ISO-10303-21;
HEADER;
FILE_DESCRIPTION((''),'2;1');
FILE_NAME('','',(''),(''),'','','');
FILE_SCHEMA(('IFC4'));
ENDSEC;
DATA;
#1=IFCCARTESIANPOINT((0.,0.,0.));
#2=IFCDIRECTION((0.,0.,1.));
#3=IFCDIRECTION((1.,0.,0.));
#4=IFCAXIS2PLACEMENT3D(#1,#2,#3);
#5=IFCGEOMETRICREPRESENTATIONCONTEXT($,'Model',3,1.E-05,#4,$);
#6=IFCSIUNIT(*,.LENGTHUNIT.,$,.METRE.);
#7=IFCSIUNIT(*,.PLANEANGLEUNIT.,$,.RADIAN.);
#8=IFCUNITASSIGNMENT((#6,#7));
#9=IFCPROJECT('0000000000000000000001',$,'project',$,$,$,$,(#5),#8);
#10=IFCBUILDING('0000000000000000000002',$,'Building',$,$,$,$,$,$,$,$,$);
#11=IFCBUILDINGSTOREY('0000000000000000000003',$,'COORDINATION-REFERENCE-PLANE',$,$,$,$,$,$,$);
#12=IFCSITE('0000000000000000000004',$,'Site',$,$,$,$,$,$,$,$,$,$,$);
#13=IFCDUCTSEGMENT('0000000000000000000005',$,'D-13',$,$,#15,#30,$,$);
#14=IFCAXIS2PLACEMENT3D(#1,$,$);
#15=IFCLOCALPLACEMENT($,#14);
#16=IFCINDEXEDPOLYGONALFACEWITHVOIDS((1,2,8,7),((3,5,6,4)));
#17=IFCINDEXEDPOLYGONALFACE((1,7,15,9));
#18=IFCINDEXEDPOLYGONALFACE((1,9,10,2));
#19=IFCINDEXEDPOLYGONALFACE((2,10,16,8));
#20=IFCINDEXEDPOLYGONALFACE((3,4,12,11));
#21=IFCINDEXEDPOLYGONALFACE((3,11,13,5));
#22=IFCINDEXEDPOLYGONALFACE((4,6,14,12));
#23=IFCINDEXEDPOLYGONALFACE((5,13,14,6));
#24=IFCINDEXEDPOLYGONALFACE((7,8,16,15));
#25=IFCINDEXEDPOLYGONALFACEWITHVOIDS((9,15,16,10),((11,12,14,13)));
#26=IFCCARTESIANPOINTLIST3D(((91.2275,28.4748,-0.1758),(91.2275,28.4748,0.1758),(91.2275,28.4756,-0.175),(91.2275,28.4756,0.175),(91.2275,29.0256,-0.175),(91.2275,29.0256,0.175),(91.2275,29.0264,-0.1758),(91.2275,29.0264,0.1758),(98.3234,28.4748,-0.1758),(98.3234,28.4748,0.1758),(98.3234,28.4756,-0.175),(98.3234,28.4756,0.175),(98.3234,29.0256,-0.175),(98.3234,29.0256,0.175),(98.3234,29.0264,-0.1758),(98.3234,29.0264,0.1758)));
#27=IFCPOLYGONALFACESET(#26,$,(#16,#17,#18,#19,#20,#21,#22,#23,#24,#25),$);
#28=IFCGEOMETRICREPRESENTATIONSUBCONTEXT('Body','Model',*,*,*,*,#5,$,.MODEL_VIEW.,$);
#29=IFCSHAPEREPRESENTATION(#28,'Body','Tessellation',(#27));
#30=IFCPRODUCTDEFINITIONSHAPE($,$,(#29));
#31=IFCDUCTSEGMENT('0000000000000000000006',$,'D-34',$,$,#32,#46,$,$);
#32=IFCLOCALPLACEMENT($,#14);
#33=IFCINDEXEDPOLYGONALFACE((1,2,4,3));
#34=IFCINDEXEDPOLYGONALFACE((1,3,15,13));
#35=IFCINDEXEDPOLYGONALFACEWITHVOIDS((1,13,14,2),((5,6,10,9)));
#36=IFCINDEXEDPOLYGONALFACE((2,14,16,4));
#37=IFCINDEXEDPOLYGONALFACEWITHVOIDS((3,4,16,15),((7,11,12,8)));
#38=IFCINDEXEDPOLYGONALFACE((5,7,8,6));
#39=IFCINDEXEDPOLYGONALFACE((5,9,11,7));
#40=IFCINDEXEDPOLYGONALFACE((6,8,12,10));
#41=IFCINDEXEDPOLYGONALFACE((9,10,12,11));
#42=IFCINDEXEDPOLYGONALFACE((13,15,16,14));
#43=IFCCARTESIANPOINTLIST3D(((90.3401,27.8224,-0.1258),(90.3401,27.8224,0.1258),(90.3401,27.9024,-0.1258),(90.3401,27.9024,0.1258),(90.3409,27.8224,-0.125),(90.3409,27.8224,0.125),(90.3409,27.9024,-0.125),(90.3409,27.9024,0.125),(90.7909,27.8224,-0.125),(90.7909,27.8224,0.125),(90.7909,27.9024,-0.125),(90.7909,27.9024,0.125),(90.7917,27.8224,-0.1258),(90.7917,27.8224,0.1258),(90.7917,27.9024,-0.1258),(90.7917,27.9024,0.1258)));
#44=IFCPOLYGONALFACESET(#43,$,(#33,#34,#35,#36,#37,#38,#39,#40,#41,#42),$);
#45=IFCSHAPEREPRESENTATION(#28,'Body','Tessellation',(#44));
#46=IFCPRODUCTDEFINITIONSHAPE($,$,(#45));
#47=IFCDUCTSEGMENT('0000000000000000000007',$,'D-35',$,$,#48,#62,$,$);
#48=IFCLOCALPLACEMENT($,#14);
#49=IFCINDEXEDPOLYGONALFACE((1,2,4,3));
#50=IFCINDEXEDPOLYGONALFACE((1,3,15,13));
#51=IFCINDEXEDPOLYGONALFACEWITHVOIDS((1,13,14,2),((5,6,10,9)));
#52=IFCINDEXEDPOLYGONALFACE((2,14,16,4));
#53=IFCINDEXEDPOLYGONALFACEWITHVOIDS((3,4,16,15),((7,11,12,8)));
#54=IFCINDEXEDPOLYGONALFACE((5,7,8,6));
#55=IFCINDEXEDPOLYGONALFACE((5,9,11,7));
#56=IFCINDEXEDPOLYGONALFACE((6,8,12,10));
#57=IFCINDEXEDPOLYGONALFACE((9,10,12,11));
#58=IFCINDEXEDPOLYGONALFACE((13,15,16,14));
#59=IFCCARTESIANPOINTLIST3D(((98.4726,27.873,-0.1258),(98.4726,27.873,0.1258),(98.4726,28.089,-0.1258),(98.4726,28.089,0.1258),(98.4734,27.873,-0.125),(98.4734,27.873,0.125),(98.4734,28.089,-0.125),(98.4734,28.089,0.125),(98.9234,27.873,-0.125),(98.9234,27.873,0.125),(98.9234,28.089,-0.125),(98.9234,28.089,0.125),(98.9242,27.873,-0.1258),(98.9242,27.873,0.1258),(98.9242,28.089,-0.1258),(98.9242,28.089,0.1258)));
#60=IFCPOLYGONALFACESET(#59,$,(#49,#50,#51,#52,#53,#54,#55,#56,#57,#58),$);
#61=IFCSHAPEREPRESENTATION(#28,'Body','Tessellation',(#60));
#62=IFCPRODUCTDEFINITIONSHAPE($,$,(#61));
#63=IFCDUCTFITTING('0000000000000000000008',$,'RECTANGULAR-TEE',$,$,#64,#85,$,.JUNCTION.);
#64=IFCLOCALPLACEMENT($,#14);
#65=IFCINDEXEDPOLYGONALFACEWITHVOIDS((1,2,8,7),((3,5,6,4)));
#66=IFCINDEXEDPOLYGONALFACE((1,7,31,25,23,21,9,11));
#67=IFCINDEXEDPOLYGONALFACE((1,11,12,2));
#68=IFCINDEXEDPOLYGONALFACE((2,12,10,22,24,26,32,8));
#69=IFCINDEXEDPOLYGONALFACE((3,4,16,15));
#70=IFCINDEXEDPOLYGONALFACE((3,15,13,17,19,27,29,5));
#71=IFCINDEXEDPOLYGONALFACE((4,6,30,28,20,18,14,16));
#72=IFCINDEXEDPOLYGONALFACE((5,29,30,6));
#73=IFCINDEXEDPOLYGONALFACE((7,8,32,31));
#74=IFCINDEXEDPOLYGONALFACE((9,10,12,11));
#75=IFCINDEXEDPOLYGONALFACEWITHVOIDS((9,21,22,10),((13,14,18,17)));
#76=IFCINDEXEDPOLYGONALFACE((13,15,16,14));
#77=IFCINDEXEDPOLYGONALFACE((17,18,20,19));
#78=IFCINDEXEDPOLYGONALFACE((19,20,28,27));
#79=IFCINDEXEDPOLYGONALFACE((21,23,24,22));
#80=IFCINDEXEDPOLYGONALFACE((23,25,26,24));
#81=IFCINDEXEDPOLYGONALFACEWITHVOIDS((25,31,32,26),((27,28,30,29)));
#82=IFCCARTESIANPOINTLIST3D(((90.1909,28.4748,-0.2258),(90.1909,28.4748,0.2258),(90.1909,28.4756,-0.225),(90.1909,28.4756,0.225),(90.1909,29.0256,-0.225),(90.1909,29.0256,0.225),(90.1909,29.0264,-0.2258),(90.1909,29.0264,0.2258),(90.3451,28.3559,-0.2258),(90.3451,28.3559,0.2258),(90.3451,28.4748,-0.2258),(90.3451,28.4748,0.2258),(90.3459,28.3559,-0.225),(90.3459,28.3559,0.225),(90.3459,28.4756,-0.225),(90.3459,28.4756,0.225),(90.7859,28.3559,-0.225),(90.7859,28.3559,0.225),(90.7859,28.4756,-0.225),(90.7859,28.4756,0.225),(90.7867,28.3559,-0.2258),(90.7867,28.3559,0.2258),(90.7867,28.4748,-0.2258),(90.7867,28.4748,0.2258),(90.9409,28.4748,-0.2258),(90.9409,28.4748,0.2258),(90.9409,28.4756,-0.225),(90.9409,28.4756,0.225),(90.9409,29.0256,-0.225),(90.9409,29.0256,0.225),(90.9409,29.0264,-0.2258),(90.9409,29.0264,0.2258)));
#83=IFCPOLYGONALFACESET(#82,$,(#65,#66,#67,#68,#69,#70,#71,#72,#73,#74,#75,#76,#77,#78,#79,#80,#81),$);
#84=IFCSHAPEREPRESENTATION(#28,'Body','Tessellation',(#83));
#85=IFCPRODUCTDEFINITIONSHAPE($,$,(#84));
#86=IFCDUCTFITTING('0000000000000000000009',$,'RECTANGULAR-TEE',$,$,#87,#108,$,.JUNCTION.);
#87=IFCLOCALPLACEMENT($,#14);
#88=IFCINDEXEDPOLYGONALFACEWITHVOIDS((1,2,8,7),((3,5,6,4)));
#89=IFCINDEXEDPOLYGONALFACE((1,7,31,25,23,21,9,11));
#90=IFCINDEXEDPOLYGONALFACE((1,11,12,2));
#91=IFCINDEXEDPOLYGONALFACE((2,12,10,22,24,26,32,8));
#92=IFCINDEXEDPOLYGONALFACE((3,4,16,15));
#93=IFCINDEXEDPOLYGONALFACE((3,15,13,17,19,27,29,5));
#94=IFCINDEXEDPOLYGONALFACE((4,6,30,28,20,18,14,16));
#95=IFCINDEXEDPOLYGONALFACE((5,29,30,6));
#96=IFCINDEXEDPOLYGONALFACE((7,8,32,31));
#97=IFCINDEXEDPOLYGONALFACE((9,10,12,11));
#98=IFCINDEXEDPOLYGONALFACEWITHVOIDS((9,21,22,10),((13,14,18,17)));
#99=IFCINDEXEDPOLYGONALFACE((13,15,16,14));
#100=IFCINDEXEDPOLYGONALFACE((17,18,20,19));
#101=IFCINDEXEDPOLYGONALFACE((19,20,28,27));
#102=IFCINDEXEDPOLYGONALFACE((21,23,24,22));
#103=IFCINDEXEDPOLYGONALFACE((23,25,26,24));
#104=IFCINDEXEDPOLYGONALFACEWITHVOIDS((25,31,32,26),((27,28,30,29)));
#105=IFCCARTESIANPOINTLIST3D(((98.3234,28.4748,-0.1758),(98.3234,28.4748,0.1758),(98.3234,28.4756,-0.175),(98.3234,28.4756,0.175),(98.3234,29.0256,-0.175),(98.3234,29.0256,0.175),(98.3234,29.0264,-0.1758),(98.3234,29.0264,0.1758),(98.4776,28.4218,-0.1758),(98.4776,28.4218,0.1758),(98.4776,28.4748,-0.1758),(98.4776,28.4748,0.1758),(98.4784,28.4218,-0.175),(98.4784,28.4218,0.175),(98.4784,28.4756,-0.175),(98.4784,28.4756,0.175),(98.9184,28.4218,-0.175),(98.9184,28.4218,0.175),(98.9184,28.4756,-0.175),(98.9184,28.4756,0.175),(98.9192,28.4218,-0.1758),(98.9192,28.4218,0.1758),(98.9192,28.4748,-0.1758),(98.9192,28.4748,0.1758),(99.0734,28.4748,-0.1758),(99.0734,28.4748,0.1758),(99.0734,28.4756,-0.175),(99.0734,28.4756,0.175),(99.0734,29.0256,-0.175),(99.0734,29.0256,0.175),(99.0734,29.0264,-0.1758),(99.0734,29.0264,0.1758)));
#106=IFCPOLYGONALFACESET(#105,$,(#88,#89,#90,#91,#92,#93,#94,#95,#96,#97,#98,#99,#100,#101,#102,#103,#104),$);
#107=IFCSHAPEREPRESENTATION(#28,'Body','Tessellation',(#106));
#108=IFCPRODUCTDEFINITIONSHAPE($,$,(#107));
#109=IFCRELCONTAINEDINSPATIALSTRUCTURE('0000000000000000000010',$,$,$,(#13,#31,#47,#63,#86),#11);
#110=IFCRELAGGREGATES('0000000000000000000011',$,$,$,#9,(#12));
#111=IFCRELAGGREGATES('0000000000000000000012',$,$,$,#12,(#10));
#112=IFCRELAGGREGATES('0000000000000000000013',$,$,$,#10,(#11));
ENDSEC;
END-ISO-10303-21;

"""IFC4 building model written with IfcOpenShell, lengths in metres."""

from ifc_helpers import new_model, si_unit, frame, origin, origin_with_axes, place, context, subcontext, project, spatial, rectangle, hollow_rectangle, extrude, boolean, element, save


model = new_model("IFC4")

# Units and contexts
model_context = context("Model", 3, precision=1e-05, world=origin_with_axes())
body_context_1 = subcontext(model_context, "Body", "Model", "MODEL_VIEW")
ifc_project = project(units=[si_unit("LENGTHUNIT", "METRE"), si_unit("PLANEANGLEUNIT", "RADIAN")], contexts=[model_context])

# Site, building, storey
site = spatial("IfcSite", under=ifc_project, Name="Site")
building = spatial("IfcBuilding", under=site, Name="Building")
storey = spatial("IfcBuildingStorey", under=building, Name="COORDINATION-REFERENCE-PLANE")

# Duct segments
duct_segment_1_placement = place(None, frame((91.2275, 28.7506, 0.0), z_axis=(1.0, 0.0, 0.0), x_axis=(0.0, 1.0, 0.0)))
element("IfcDuctSegment", 1, at=duct_segment_1_placement, inside=storey, Name="D-13", context=body_context_1, shape_type="SweptSolid", body=[
    extrude(hollow_rectangle(XDim=0.5516, YDim=0.3516, WallThickness=0.0008), origin(), (0.0, 0.0, 1.0), 7.0959),
])
duct_segment_2_placement = place(None, frame((90.5659, 27.8224, 0.0), z_axis=(0.0, 1.0, 0.0), x_axis=(1.0, 0.0, 0.0)))
element("IfcDuctSegment", 2, at=duct_segment_2_placement, inside=storey, Name="D-34", context=body_context_1, shape_type="SweptSolid", body=[
    extrude(hollow_rectangle(XDim=0.4516, YDim=0.2516, WallThickness=0.0008), origin(), (0.0, 0.0, 1.0), 0.08),
])
duct_segment_3_placement = place(None, frame((98.6984, 27.873, 0.0), z_axis=(0.0, 1.0, 0.0), x_axis=(1.0, 0.0, 0.0)))
element("IfcDuctSegment", 3, at=duct_segment_3_placement, inside=storey, Name="D-35", context=body_context_1, shape_type="SweptSolid", body=[
    extrude(hollow_rectangle(XDim=0.4516, YDim=0.2516, WallThickness=0.0008), origin(), (0.0, 0.0, 1.0), 0.216),
])

# Duct fittings
duct_fitting_1_placement = place(None, frame((90.5659, 28.7506, 0.0), z_axis=(1.0, 0.0, 0.0), x_axis=(0.0, -1.0, 0.0)))
solid_1 = boolean("UNION", extrude(rectangle(XDim=0.55, YDim=0.45), frame((0.0, 0.0, -0.375), z_axis=(0.0, 0.0, 1.0), x_axis=(1.0, 0.0, 0.0)), (0.0, 0.0, 1.0), 0.75), extrude(rectangle(XDim=0.44, YDim=0.45), frame((0.0, 0.0, 0.0), z_axis=(1.0, 0.0, 0.0), x_axis=(0.0, 0.0, -1.0)), (0.0, 0.0, 1.0), 0.3947))
element("IfcDuctFitting", 4, at=duct_fitting_1_placement, inside=storey, Name="RECTANGULAR-TEE", PredefinedType="JUNCTION", context=body_context_1, shape_type="CSG", body=[
    boolean("DIFFERENCE", boolean("UNION", extrude(rectangle(XDim=0.5516, YDim=0.4516), frame((0.0, 0.0, -0.375), z_axis=(0.0, 0.0, 1.0), x_axis=(1.0, 0.0, 0.0)), (0.0, 0.0, 1.0), 0.75), extrude(rectangle(XDim=0.4416, YDim=0.4516), frame((0.0, 0.0, 0.0), z_axis=(1.0, 0.0, 0.0), x_axis=(0.0, 0.0, -1.0)), (0.0, 0.0, 1.0), 0.3947)), solid_1),
])
duct_fitting_2_placement = place(None, frame((98.6984, 28.7506, 0.0), z_axis=(1.0, 0.0, 0.0), x_axis=(0.0, -1.0, 0.0)))
solid_2 = boolean("UNION", extrude(rectangle(XDim=0.55, YDim=0.35), frame((0.0, 0.0, -0.375), z_axis=(0.0, 0.0, 1.0), x_axis=(1.0, 0.0, 0.0)), (0.0, 0.0, 1.0), 0.75), extrude(rectangle(XDim=0.44, YDim=0.35), frame((0.0, 0.0, 0.0), z_axis=(1.0, 0.0, 0.0), x_axis=(0.0, 0.0, -1.0)), (0.0, 0.0, 1.0), 0.3288))
element("IfcDuctFitting", 5, at=duct_fitting_2_placement, inside=storey, Name="RECTANGULAR-TEE", PredefinedType="JUNCTION", context=body_context_1, shape_type="CSG", body=[
    boolean("DIFFERENCE", boolean("UNION", extrude(rectangle(XDim=0.5516, YDim=0.3516), frame((0.0, 0.0, -0.375), z_axis=(0.0, 0.0, 1.0), x_axis=(1.0, 0.0, 0.0)), (0.0, 0.0, 1.0), 0.75), extrude(rectangle(XDim=0.4416, YDim=0.3516), frame((0.0, 0.0, 0.0), z_axis=(1.0, 0.0, 0.0), x_axis=(0.0, 0.0, -1.0)), (0.0, 0.0, 1.0), 0.3288)), solid_2),
])

save(model, "model.ifc")
